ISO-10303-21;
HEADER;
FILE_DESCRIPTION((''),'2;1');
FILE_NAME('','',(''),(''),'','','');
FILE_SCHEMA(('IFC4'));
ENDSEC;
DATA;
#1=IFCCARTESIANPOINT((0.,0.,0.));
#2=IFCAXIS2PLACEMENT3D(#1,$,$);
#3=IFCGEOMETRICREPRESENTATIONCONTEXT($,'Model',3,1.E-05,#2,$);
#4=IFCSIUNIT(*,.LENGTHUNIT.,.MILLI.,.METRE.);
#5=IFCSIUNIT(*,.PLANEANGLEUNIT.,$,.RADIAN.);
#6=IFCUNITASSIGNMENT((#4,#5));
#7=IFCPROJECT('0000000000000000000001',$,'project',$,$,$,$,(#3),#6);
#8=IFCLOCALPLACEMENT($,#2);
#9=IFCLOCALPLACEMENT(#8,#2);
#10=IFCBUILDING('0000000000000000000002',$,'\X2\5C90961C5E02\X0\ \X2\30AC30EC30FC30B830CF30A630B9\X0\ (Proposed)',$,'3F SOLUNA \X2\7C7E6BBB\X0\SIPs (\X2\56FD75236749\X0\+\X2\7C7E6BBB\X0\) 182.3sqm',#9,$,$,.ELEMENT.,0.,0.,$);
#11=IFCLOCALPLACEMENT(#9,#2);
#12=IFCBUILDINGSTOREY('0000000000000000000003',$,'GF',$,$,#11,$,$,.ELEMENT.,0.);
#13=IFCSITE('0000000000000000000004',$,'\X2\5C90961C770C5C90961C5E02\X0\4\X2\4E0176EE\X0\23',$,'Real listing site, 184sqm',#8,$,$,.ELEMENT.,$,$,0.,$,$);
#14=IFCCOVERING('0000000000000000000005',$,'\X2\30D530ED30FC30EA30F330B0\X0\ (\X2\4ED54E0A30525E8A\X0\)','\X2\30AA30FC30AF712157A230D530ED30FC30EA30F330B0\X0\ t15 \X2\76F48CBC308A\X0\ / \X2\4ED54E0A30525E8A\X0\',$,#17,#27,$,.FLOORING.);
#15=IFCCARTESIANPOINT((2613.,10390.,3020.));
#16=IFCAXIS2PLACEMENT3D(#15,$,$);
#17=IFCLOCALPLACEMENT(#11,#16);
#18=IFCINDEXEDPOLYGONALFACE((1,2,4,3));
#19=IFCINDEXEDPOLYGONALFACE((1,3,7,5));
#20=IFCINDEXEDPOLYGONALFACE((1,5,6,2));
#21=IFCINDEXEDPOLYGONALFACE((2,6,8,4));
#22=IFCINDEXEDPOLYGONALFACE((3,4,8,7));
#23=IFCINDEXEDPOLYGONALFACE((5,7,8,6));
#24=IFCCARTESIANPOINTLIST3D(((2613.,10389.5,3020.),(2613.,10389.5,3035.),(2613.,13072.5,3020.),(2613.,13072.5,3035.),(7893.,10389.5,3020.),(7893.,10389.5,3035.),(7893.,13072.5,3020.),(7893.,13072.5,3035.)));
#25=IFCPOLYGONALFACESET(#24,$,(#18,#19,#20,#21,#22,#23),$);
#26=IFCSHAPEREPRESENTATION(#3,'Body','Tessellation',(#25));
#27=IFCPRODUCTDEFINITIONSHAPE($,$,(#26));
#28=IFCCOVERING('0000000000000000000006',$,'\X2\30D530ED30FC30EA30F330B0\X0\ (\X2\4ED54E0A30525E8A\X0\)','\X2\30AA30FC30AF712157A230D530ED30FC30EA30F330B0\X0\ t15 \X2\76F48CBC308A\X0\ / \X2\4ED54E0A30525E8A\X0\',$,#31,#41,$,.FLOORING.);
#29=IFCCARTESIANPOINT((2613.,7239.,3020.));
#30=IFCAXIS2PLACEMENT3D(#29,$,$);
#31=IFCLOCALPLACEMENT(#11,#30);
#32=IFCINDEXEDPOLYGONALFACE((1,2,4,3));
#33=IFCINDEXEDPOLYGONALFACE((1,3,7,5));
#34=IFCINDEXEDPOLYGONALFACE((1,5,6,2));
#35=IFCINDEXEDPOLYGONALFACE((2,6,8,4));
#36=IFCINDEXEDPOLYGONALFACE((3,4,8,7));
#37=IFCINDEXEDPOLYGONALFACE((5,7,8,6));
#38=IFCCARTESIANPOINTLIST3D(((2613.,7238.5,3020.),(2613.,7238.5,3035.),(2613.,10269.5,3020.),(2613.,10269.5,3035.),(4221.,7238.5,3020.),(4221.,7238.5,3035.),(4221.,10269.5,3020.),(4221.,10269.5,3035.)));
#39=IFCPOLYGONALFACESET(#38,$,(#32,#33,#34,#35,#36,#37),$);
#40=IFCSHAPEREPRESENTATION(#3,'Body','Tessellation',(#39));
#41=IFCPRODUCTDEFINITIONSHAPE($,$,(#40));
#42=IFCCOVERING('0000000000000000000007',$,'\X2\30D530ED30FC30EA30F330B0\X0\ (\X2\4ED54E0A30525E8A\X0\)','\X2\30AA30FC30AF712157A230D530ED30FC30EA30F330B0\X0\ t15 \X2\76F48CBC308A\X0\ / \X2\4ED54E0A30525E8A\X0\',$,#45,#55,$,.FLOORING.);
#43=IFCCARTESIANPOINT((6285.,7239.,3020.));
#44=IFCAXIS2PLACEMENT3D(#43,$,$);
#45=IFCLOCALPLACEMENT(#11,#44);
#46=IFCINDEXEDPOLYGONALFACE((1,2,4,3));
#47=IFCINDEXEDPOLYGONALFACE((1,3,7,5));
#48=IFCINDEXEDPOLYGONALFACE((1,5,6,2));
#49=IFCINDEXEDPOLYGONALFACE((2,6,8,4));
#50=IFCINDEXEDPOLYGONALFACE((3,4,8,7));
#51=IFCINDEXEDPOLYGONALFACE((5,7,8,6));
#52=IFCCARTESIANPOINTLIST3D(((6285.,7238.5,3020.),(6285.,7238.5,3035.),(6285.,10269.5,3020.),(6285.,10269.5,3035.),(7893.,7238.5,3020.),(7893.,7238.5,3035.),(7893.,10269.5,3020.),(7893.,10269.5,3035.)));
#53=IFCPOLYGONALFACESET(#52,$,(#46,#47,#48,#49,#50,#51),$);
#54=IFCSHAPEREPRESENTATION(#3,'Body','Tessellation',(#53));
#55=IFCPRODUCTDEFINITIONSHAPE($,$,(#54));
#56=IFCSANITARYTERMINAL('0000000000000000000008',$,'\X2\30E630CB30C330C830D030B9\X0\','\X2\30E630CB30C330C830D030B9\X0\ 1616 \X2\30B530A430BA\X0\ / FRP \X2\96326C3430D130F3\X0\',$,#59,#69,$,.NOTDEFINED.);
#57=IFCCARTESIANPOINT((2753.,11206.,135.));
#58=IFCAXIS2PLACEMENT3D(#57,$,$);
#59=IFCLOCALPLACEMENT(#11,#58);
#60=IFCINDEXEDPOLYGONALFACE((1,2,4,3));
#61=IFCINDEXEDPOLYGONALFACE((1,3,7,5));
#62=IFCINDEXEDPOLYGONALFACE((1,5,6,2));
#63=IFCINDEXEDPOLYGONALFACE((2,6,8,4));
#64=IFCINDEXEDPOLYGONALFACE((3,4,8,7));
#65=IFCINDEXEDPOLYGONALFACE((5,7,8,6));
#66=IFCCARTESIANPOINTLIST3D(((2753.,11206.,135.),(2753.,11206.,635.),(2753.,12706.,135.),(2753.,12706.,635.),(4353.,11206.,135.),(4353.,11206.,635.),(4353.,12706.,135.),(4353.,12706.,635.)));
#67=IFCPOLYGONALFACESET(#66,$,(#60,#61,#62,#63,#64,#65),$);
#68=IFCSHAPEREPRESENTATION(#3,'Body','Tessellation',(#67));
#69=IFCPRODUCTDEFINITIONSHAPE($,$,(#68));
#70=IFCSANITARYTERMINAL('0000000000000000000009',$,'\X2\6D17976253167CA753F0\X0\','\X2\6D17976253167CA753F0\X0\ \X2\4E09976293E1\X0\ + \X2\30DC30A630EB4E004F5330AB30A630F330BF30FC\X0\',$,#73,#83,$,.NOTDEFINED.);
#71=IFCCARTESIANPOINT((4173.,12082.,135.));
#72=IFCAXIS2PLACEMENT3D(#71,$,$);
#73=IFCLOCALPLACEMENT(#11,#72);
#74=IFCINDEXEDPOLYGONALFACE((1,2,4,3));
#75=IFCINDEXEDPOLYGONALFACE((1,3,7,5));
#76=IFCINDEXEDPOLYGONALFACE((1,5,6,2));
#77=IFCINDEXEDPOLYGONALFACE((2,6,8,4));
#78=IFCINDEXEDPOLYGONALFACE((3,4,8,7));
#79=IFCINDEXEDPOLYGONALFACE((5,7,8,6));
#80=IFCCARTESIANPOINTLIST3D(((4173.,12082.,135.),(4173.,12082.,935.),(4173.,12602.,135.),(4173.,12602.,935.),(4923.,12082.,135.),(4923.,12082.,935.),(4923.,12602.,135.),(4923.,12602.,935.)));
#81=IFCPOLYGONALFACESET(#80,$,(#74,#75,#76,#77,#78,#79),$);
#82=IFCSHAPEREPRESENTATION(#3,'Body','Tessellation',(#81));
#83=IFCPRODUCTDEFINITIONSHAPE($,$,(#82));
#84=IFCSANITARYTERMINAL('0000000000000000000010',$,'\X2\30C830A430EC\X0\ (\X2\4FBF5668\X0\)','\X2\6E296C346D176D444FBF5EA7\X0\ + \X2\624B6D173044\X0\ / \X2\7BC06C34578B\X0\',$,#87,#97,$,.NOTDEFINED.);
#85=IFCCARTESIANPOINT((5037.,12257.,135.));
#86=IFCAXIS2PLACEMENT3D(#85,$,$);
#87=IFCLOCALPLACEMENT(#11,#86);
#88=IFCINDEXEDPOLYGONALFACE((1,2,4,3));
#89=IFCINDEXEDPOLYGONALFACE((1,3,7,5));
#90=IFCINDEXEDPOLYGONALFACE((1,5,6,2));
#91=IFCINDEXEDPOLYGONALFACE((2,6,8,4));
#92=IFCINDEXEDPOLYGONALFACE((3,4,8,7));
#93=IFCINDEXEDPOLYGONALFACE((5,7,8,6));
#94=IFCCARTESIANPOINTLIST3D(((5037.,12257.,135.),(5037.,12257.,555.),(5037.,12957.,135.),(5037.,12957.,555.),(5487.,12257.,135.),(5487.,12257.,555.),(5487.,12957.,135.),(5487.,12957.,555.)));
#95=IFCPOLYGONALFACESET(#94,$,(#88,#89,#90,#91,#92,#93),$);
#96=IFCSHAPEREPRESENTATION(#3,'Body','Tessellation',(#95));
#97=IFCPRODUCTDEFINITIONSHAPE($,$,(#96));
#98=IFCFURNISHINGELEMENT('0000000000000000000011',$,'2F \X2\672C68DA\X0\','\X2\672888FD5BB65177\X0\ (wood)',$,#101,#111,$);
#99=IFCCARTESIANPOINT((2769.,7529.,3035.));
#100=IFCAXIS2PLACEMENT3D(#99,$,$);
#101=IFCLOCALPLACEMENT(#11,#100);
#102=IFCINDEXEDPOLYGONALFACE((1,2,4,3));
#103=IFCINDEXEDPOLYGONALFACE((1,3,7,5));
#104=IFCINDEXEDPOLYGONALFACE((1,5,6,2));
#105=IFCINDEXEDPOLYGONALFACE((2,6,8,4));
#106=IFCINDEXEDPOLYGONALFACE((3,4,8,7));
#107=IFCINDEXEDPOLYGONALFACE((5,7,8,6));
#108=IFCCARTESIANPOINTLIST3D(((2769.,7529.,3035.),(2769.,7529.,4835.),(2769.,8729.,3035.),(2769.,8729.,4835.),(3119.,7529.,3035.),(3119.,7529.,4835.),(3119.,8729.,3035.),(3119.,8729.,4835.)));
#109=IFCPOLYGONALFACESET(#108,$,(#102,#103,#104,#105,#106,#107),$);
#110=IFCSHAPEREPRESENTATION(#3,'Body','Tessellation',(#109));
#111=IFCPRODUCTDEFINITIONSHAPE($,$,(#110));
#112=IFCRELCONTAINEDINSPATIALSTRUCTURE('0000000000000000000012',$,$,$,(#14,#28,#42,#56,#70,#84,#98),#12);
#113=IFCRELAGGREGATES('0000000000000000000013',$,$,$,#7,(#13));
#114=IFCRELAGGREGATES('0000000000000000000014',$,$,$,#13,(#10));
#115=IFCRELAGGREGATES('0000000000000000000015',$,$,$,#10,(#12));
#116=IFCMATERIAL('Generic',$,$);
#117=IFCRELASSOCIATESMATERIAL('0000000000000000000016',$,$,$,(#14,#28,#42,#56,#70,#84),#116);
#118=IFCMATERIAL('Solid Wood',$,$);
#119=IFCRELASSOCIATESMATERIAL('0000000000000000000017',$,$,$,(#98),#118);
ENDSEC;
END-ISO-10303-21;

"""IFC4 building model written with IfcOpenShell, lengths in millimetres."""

from ifc_helpers import new_model, si_unit, frame, frame_2d, origin, place, context, project, spatial, rectangle, extrude, material, element, save


model = new_model("IFC4")

# Units and contexts
model_context = context("Model", 3, precision=1e-05, world=origin())
ifc_project = project(units=[si_unit("LENGTHUNIT", "METRE", prefix="MILLI"), si_unit("PLANEANGLEUNIT", "RADIAN")], contexts=[model_context])

# Site, building, storey
site_placement = place(None, origin())
site = spatial("IfcSite", under=ifc_project, at=site_placement, Name="岐阜県岐阜市4丁目23", ObjectType="Real listing site, 184sqm", CompositionType="ELEMENT", RefElevation=0.0)
building_placement = place(site_placement, origin())
building = spatial("IfcBuilding", under=site, at=building_placement, Name="岐阜市 ガレージハウス (Proposed)", ObjectType="3F SOLUNA 籾殻SIPs (国産杉+籾殻) 182.3sqm", CompositionType="ELEMENT", ElevationOfRefHeight=0.0, ElevationOfTerrain=0.0)
storey_placement = place(building_placement, origin())
storey = spatial("IfcBuildingStorey", under=building, at=storey_placement, Name="GF", CompositionType="ELEMENT", Elevation=0.0)

# Shared definitions
ifc_material_1 = material(Name="Solid Wood")

# Coverings
ifc_material_2 = material(Name="Generic")
covering_1_placement = place(storey_placement, frame((2613.0, 10390.0, 3020.0)))
element("IfcCovering", 1, at=covering_1_placement, inside=storey, material=ifc_material_2, Name="フローリング (仕上げ床)", Description="オーク無垢フローリング t15 直貼り / 仕上げ床", PredefinedType="FLOORING", context=model_context, shape_type="SweptSolid", body=[
    extrude(rectangle(XDim=5280.0, YDim=2683.0, at=frame_2d((2640.0, 1341.0))), frame((2613.0, 10390.0, 3020.0)), (0.0, 0.0, 1.0), 15.0),
])
covering_2_placement = place(storey_placement, frame((2613.0, 7239.0, 3020.0)))
element("IfcCovering", 2, at=covering_2_placement, inside=storey, material=ifc_material_2, Name="フローリング (仕上げ床)", Description="オーク無垢フローリング t15 直貼り / 仕上げ床", PredefinedType="FLOORING", context=model_context, shape_type="SweptSolid", body=[
    extrude(rectangle(XDim=1608.0, YDim=3031.0, at=frame_2d((804.0, 1515.0))), frame((2613.0, 7239.0, 3020.0)), (0.0, 0.0, 1.0), 15.0),
])
covering_3_placement = place(storey_placement, frame((6285.0, 7239.0, 3020.0)))
element("IfcCovering", 3, at=covering_3_placement, inside=storey, material=ifc_material_2, Name="フローリング (仕上げ床)", Description="オーク無垢フローリング t15 直貼り / 仕上げ床", PredefinedType="FLOORING", context=model_context, shape_type="SweptSolid", body=[
    extrude(rectangle(XDim=1608.0, YDim=3031.0, at=frame_2d((804.0, 1515.0))), frame((6285.0, 7239.0, 3020.0)), (0.0, 0.0, 1.0), 15.0),
])

# Sanitary terminals
sanitary_terminal_1_placement = place(storey_placement, frame((2753.0, 11206.0, 135.0)))
element("IfcSanitaryTerminal", 4, at=sanitary_terminal_1_placement, inside=storey, material=ifc_material_2, Name="ユニットバス", Description="ユニットバス 1616 サイズ / FRP 防水パン", PredefinedType="NOTDEFINED", context=model_context, shape_type="SweptSolid", body=[
    extrude(rectangle(XDim=1600.0, YDim=1500.0, at=frame_2d((800.0, 750.0))), frame((2753.0, 11206.0, 135.0)), (0.0, 0.0, 1.0), 500.0),
])
sanitary_terminal_2_placement = place(storey_placement, frame((4173.0, 12082.0, 135.0)))
element("IfcSanitaryTerminal", 5, at=sanitary_terminal_2_placement, inside=storey, material=ifc_material_2, Name="洗面化粧台", Description="洗面化粧台 三面鏡 + ボウル一体カウンター", PredefinedType="NOTDEFINED", context=model_context, shape_type="SweptSolid", body=[
    extrude(rectangle(XDim=750.0, YDim=520.0, at=frame_2d((375.0, 260.0))), frame((4173.0, 12082.0, 135.0)), (0.0, 0.0, 1.0), 800.0),
])
sanitary_terminal_3_placement = place(storey_placement, frame((5037.0, 12257.0, 135.0)))
element("IfcSanitaryTerminal", 6, at=sanitary_terminal_3_placement, inside=storey, material=ifc_material_2, Name="トイレ (便器)", Description="温水洗浄便座 + 手洗い / 節水型", PredefinedType="NOTDEFINED", context=model_context, shape_type="SweptSolid", body=[
    extrude(rectangle(XDim=450.0, YDim=700.0, at=frame_2d((225.0, 350.0))), frame((5037.0, 12257.0, 135.0)), (0.0, 0.0, 1.0), 420.0),
])

# Furnishing element
furnishing_placement = place(storey_placement, frame((2769.0, 7529.0, 3035.0)))
element("IfcFurnishingElement", 7, at=furnishing_placement, inside=storey, material=ifc_material_1, Name="2F 本棚", Description="木製家具 (wood)", context=model_context, shape_type="SweptSolid", body=[
    extrude(rectangle(XDim=350.0, YDim=1200.0, at=frame_2d((175.0, 600.0))), frame((2769.0, 7529.0, 3035.0)), (0.0, 0.0, 1.0), 1800.0),
])

save(model, "model.ifc")
